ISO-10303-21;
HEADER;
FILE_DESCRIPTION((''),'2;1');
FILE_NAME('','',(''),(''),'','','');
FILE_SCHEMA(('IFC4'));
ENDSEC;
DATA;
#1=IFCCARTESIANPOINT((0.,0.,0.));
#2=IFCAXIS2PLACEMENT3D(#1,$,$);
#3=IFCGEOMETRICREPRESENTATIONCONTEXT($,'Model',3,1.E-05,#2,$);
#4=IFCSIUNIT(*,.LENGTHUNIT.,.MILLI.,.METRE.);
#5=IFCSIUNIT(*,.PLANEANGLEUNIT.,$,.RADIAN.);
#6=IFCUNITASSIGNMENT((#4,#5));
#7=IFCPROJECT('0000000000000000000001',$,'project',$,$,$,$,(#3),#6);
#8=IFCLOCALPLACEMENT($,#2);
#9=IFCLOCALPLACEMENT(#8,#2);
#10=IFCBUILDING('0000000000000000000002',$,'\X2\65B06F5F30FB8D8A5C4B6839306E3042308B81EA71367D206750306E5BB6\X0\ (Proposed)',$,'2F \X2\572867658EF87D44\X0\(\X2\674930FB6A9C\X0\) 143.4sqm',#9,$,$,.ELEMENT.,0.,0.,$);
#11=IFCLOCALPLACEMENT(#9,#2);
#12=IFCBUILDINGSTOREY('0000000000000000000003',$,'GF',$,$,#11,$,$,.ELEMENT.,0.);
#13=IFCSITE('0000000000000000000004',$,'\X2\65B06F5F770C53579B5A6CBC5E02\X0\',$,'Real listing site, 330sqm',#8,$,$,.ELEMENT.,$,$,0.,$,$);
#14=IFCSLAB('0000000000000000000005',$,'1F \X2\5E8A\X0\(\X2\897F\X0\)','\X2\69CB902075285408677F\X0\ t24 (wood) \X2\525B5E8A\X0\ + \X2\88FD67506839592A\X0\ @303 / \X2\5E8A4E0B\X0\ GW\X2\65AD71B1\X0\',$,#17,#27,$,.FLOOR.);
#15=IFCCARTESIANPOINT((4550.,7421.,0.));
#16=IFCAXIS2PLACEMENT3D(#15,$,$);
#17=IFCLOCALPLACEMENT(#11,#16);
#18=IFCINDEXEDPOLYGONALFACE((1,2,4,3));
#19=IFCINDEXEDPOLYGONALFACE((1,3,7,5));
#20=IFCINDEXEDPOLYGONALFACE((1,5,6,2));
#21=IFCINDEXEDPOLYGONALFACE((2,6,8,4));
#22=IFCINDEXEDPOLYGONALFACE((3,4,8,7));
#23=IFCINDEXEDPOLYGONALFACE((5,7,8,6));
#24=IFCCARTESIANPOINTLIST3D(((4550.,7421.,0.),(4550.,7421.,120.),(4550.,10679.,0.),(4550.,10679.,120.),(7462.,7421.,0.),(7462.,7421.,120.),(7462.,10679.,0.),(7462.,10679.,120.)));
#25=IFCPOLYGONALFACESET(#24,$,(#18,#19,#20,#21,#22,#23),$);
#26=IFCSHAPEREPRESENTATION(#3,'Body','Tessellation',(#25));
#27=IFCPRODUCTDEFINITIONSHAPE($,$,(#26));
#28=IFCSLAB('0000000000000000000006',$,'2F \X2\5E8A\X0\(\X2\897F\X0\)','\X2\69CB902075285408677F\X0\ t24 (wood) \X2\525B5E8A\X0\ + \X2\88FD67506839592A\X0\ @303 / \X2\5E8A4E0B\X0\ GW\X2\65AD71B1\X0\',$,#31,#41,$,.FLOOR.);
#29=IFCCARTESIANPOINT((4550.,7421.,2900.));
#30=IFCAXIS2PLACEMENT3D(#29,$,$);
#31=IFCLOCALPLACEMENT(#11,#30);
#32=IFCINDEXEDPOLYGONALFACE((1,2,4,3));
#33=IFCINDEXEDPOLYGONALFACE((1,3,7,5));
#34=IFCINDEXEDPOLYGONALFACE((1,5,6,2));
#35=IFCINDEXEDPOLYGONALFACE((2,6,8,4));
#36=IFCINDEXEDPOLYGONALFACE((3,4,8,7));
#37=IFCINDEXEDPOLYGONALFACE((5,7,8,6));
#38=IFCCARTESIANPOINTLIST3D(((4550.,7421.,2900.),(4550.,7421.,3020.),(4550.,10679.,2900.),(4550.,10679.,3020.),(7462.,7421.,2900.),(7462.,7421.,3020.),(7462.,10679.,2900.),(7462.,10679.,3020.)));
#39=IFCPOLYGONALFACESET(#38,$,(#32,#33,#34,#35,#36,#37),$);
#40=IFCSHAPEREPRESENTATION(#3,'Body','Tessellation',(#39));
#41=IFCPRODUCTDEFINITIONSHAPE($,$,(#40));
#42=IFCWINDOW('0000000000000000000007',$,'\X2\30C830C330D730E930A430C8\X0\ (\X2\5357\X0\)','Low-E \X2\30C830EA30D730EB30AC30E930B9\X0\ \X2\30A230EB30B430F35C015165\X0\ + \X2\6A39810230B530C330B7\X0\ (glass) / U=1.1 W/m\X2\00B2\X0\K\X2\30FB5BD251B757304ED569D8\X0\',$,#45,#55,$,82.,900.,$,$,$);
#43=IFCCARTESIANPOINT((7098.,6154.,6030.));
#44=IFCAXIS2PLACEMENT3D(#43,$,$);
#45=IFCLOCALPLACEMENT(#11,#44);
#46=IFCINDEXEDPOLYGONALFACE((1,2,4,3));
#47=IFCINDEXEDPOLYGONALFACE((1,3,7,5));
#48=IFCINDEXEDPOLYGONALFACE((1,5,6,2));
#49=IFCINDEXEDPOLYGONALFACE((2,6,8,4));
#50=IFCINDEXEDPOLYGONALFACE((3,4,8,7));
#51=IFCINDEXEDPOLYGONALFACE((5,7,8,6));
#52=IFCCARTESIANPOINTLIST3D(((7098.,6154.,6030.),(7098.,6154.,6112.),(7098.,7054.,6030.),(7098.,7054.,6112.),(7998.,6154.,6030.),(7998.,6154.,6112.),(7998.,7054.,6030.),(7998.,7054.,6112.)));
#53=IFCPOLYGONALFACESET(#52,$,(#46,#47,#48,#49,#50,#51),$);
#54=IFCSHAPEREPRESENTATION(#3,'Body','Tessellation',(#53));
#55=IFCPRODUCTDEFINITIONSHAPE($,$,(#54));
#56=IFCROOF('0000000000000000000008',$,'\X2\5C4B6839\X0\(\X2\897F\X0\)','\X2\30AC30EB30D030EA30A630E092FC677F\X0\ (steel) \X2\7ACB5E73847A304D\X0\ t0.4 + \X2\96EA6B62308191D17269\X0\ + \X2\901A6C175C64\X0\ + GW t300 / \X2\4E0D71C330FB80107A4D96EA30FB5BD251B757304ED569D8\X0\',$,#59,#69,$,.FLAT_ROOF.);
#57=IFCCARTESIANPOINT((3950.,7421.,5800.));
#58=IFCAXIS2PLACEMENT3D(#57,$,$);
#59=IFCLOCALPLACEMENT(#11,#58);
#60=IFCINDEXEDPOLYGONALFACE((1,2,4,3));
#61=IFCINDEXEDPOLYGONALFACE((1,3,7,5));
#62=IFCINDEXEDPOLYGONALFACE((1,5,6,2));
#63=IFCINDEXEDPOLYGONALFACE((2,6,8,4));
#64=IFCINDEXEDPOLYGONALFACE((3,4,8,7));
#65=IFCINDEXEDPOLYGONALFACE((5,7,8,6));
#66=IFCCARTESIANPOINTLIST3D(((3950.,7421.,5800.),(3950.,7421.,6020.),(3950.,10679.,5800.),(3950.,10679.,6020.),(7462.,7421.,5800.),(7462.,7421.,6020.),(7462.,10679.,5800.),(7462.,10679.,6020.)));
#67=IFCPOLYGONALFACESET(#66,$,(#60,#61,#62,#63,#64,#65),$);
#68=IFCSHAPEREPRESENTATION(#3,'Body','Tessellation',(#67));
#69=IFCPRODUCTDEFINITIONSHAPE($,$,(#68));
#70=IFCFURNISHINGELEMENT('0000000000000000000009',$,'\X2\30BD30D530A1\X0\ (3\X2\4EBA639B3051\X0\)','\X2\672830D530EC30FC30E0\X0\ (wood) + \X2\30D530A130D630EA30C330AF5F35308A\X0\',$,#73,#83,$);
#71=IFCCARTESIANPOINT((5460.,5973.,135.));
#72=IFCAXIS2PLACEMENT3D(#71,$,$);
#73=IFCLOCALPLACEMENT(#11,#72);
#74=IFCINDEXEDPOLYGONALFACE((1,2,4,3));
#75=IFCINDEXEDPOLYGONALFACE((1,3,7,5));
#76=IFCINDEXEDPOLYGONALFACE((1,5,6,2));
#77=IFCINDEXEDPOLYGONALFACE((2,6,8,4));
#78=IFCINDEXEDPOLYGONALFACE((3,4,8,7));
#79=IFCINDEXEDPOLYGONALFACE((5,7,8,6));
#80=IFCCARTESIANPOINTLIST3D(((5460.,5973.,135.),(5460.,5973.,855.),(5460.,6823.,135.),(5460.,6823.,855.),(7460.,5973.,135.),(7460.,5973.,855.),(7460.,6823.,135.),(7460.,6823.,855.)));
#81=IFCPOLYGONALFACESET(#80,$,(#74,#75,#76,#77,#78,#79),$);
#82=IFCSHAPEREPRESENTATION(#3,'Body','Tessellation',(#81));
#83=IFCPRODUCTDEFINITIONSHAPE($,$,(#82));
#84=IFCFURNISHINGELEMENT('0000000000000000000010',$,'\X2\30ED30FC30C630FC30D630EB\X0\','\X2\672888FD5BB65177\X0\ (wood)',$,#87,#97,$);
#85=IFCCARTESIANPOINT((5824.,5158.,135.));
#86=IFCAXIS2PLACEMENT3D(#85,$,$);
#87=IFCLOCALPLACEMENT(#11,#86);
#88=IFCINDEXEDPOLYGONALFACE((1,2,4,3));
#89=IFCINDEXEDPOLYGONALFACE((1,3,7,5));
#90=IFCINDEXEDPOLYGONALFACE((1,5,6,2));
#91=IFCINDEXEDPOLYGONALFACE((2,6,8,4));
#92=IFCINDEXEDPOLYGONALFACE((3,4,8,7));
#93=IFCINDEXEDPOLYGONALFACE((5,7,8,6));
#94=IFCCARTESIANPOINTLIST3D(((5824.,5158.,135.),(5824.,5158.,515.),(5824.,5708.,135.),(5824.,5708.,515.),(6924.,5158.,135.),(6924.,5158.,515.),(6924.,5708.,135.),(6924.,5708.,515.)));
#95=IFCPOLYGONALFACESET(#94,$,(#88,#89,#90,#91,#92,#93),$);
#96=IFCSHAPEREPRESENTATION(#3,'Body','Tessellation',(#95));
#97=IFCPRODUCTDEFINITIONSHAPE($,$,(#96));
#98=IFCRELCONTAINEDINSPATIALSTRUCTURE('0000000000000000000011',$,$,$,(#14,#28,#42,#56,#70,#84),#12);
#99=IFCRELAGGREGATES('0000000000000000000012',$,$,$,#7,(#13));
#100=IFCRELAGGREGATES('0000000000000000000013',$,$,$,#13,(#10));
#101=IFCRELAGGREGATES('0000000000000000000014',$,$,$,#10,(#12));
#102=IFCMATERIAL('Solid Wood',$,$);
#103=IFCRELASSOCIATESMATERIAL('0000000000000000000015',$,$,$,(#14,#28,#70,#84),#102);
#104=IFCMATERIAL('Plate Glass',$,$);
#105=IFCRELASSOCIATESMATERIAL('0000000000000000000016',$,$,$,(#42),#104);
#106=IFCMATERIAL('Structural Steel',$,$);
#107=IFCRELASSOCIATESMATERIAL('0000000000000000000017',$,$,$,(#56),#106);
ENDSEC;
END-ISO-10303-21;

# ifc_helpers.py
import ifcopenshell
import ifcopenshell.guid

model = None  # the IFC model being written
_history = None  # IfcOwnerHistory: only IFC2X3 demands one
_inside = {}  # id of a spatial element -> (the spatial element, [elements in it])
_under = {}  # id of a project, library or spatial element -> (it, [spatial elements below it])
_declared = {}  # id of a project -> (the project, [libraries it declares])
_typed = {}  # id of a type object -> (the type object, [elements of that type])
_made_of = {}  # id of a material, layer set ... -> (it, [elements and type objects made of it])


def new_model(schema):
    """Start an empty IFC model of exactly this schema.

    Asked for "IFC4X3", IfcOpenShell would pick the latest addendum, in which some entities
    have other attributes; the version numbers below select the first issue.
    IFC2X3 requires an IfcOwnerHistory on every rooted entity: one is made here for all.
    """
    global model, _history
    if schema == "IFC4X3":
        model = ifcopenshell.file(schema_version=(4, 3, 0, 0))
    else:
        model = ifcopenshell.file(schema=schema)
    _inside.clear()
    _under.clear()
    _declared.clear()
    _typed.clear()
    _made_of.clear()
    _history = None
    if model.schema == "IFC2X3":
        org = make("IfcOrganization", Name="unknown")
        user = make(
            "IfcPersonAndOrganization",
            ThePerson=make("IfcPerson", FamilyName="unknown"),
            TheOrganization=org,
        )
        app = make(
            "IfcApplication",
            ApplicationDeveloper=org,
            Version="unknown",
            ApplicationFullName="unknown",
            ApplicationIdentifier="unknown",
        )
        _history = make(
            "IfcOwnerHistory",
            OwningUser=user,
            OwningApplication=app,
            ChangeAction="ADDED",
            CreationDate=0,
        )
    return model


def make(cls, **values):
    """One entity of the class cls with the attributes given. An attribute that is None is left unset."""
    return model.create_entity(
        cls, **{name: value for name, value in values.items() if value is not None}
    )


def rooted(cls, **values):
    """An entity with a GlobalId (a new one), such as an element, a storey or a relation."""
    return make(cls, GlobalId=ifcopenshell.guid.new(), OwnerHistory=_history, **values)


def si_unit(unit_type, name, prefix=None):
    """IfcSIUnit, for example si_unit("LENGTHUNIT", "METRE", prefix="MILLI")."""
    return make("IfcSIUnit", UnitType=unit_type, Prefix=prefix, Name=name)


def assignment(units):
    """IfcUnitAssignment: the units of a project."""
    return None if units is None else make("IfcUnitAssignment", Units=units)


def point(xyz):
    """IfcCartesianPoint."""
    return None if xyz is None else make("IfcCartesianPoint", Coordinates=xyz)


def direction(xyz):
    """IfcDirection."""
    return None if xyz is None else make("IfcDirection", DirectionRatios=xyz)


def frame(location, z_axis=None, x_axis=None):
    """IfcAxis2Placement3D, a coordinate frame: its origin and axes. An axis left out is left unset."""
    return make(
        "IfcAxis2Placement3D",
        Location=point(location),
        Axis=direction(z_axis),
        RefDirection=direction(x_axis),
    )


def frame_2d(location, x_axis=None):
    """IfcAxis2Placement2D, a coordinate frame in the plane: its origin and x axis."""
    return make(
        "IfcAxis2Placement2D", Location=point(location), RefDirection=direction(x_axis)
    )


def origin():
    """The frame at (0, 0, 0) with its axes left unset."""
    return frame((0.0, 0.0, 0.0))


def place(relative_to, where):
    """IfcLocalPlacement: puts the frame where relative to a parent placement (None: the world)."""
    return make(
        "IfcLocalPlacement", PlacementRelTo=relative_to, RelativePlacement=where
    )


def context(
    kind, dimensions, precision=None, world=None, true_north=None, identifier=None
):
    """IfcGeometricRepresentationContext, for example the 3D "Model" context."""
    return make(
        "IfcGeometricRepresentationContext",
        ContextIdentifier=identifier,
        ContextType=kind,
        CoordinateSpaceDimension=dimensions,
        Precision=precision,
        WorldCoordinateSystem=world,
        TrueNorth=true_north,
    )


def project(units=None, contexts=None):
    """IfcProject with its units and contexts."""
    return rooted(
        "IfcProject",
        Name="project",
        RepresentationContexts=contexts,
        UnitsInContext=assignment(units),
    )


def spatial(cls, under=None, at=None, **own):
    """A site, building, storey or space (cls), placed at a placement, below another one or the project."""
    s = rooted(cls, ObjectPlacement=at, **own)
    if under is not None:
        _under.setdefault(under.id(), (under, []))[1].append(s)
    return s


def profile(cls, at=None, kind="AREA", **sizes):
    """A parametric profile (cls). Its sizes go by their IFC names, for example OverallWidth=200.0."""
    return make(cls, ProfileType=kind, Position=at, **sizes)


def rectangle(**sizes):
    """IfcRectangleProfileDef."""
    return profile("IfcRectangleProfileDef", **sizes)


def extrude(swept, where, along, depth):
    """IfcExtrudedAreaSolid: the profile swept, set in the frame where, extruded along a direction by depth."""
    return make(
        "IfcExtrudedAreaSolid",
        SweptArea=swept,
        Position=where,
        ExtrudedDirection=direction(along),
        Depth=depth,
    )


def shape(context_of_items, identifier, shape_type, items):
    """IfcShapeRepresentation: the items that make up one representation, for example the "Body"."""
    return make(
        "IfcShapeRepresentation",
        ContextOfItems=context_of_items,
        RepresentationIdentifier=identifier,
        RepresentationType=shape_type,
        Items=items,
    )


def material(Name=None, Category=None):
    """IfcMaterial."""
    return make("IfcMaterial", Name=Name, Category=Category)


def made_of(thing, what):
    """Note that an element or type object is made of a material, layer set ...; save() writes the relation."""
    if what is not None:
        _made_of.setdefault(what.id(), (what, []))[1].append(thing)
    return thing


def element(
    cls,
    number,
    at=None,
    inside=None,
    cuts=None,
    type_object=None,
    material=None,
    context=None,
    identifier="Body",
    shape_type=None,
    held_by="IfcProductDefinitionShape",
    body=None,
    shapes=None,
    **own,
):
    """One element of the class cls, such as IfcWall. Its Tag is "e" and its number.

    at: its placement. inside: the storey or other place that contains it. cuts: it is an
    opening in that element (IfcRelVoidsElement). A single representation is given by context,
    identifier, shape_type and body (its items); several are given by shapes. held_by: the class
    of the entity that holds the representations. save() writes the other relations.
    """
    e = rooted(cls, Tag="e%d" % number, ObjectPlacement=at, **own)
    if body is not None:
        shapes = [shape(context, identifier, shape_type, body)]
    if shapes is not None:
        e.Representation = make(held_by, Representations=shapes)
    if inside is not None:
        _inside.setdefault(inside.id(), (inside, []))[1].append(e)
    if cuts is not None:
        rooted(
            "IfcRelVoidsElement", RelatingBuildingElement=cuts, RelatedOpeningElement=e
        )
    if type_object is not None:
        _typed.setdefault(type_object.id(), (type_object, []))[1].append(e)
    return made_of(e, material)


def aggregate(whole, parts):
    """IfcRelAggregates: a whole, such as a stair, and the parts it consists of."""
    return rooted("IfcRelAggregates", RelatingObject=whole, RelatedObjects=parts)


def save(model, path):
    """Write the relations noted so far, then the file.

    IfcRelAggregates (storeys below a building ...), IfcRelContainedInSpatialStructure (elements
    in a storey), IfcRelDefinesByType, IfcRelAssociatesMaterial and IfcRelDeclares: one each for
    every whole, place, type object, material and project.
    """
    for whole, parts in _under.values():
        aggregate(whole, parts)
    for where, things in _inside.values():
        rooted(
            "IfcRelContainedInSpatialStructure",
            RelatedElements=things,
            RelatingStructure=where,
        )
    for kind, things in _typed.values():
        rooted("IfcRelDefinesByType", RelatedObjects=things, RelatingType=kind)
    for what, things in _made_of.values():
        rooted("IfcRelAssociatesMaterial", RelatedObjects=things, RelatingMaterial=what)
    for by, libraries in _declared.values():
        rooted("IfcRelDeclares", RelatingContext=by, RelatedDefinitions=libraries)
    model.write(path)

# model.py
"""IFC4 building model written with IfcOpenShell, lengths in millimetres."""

from ifc_helpers import new_model, si_unit, frame, frame_2d, origin, place, context, project, spatial, rectangle, extrude, material, element, save


model = new_model("IFC4")

# Units and contexts
model_context = context("Model", 3, precision=1e-05, world=origin())
ifc_project = project(units=[si_unit("LENGTHUNIT", "METRE", prefix="MILLI"), si_unit("PLANEANGLEUNIT", "RADIAN")], contexts=[model_context])

# Site, building, storey
site_placement = place(None, origin())
site = spatial("IfcSite", under=ifc_project, at=site_placement, Name="新潟県南魚沼市", ObjectType="Real listing site, 330sqm", CompositionType="ELEMENT", RefElevation=0.0)
building_placement = place(site_placement, origin())
building = spatial("IfcBuilding", under=site, at=building_placement, Name="新潟・越屋根のある自然素材の家 (Proposed)", ObjectType="2F 在来軸組(杉・檜) 143.4sqm", CompositionType="ELEMENT", ElevationOfRefHeight=0.0, ElevationOfTerrain=0.0)
storey_placement = place(building_placement, origin())
storey = spatial("IfcBuildingStorey", under=building, at=storey_placement, Name="GF", CompositionType="ELEMENT", Elevation=0.0)

# Shared definitions
ifc_material_1 = material(Name="Solid Wood")

# Slabs
slab_1_placement = place(storey_placement, frame((4550.0, 7421.0, 0.0)))
element("IfcSlab", 1, at=slab_1_placement, inside=storey, material=ifc_material_1, Name="1F 床(西)", Description="構造用合板 t24 (wood) 剛床 + 製材根太 @303 / 床下 GW断熱", PredefinedType="FLOOR", context=model_context, shape_type="SweptSolid", body=[
    extrude(rectangle(XDim=2912.0, YDim=3258.0, at=frame_2d((1456.0, 1629.0))), frame((4550.0, 7421.0, 0.0)), (0.0, 0.0, 1.0), 120.0),
])
slab_2_placement = place(storey_placement, frame((4550.0, 7421.0, 2900.0)))
element("IfcSlab", 2, at=slab_2_placement, inside=storey, material=ifc_material_1, Name="2F 床(西)", Description="構造用合板 t24 (wood) 剛床 + 製材根太 @303 / 床下 GW断熱", PredefinedType="FLOOR", context=model_context, shape_type="SweptSolid", body=[
    extrude(rectangle(XDim=2912.0, YDim=3258.0, at=frame_2d((1456.0, 1629.0))), frame((4550.0, 7421.0, 2900.0)), (0.0, 0.0, 1.0), 120.0),
])

# Window
ifc_material_2 = material(Name="Plate Glass")
window_placement = place(storey_placement, frame((7098.0, 6154.0, 6030.0)))
element("IfcWindow", 3, at=window_placement, inside=storey, material=ifc_material_2, Name="トップライト (南)", Description="Low-E トリプルガラス アルゴン封入 + 樹脂サッシ (glass) / U=1.1 W/m²K・寒冷地仕様", OverallHeight=82.0, OverallWidth=900.0, context=model_context, shape_type="SweptSolid", body=[
    extrude(rectangle(XDim=900.0, YDim=900.0, at=frame_2d((450.0, 450.0))), frame((7098.0, 6154.0, 6030.0)), (0.0, 0.0, 1.0), 82.0),
])

# Roof
ifc_material_3 = material(Name="Structural Steel")
for number, where, name in (
    (4, (3950.0, 7421.0, 5800.0), "屋根(西)"),
):
    element("IfcRoof", number, at=place(storey_placement, frame(where)), inside=storey, material=ifc_material_3, Name=name, Description="ガルバリウム鋼板 (steel) 立平葺き t0.4 + 雪止め金物 + 通気層 + GW t300 / 不燃・耐積雪・寒冷地仕様", PredefinedType="FLAT_ROOF", context=model_context, shape_type="SweptSolid", body=[
        extrude(rectangle(XDim=3512.0, YDim=3258.0, at=frame_2d((1756.0, 1629.0))), frame((3950.0, 7421.0, 5800.0)), (0.0, 0.0, 1.0), 220.0),
    ])

# Furnishing elements
furnishing_1_placement = place(storey_placement, frame((5460.0, 5973.0, 135.0)))
element("IfcFurnishingElement", 5, at=furnishing_1_placement, inside=storey, material=ifc_material_1, Name="ソファ (3人掛け)", Description="木フレーム (wood) + ファブリック張り", context=model_context, shape_type="SweptSolid", body=[
    extrude(rectangle(XDim=2000.0, YDim=850.0, at=frame_2d((1000.0, 425.0))), frame((5460.0, 5973.0, 135.0)), (0.0, 0.0, 1.0), 720.0),
])
furnishing_2_placement = place(storey_placement, frame((5824.0, 5158.0, 135.0)))
element("IfcFurnishingElement", 6, at=furnishing_2_placement, inside=storey, material=ifc_material_1, Name="ローテーブル", Description="木製家具 (wood)", context=model_context, shape_type="SweptSolid", body=[
    extrude(rectangle(XDim=1100.0, YDim=550.0, at=frame_2d((550.0, 275.0))), frame((5824.0, 5158.0, 135.0)), (0.0, 0.0, 1.0), 380.0),
])

save(model, "model.ifc")
